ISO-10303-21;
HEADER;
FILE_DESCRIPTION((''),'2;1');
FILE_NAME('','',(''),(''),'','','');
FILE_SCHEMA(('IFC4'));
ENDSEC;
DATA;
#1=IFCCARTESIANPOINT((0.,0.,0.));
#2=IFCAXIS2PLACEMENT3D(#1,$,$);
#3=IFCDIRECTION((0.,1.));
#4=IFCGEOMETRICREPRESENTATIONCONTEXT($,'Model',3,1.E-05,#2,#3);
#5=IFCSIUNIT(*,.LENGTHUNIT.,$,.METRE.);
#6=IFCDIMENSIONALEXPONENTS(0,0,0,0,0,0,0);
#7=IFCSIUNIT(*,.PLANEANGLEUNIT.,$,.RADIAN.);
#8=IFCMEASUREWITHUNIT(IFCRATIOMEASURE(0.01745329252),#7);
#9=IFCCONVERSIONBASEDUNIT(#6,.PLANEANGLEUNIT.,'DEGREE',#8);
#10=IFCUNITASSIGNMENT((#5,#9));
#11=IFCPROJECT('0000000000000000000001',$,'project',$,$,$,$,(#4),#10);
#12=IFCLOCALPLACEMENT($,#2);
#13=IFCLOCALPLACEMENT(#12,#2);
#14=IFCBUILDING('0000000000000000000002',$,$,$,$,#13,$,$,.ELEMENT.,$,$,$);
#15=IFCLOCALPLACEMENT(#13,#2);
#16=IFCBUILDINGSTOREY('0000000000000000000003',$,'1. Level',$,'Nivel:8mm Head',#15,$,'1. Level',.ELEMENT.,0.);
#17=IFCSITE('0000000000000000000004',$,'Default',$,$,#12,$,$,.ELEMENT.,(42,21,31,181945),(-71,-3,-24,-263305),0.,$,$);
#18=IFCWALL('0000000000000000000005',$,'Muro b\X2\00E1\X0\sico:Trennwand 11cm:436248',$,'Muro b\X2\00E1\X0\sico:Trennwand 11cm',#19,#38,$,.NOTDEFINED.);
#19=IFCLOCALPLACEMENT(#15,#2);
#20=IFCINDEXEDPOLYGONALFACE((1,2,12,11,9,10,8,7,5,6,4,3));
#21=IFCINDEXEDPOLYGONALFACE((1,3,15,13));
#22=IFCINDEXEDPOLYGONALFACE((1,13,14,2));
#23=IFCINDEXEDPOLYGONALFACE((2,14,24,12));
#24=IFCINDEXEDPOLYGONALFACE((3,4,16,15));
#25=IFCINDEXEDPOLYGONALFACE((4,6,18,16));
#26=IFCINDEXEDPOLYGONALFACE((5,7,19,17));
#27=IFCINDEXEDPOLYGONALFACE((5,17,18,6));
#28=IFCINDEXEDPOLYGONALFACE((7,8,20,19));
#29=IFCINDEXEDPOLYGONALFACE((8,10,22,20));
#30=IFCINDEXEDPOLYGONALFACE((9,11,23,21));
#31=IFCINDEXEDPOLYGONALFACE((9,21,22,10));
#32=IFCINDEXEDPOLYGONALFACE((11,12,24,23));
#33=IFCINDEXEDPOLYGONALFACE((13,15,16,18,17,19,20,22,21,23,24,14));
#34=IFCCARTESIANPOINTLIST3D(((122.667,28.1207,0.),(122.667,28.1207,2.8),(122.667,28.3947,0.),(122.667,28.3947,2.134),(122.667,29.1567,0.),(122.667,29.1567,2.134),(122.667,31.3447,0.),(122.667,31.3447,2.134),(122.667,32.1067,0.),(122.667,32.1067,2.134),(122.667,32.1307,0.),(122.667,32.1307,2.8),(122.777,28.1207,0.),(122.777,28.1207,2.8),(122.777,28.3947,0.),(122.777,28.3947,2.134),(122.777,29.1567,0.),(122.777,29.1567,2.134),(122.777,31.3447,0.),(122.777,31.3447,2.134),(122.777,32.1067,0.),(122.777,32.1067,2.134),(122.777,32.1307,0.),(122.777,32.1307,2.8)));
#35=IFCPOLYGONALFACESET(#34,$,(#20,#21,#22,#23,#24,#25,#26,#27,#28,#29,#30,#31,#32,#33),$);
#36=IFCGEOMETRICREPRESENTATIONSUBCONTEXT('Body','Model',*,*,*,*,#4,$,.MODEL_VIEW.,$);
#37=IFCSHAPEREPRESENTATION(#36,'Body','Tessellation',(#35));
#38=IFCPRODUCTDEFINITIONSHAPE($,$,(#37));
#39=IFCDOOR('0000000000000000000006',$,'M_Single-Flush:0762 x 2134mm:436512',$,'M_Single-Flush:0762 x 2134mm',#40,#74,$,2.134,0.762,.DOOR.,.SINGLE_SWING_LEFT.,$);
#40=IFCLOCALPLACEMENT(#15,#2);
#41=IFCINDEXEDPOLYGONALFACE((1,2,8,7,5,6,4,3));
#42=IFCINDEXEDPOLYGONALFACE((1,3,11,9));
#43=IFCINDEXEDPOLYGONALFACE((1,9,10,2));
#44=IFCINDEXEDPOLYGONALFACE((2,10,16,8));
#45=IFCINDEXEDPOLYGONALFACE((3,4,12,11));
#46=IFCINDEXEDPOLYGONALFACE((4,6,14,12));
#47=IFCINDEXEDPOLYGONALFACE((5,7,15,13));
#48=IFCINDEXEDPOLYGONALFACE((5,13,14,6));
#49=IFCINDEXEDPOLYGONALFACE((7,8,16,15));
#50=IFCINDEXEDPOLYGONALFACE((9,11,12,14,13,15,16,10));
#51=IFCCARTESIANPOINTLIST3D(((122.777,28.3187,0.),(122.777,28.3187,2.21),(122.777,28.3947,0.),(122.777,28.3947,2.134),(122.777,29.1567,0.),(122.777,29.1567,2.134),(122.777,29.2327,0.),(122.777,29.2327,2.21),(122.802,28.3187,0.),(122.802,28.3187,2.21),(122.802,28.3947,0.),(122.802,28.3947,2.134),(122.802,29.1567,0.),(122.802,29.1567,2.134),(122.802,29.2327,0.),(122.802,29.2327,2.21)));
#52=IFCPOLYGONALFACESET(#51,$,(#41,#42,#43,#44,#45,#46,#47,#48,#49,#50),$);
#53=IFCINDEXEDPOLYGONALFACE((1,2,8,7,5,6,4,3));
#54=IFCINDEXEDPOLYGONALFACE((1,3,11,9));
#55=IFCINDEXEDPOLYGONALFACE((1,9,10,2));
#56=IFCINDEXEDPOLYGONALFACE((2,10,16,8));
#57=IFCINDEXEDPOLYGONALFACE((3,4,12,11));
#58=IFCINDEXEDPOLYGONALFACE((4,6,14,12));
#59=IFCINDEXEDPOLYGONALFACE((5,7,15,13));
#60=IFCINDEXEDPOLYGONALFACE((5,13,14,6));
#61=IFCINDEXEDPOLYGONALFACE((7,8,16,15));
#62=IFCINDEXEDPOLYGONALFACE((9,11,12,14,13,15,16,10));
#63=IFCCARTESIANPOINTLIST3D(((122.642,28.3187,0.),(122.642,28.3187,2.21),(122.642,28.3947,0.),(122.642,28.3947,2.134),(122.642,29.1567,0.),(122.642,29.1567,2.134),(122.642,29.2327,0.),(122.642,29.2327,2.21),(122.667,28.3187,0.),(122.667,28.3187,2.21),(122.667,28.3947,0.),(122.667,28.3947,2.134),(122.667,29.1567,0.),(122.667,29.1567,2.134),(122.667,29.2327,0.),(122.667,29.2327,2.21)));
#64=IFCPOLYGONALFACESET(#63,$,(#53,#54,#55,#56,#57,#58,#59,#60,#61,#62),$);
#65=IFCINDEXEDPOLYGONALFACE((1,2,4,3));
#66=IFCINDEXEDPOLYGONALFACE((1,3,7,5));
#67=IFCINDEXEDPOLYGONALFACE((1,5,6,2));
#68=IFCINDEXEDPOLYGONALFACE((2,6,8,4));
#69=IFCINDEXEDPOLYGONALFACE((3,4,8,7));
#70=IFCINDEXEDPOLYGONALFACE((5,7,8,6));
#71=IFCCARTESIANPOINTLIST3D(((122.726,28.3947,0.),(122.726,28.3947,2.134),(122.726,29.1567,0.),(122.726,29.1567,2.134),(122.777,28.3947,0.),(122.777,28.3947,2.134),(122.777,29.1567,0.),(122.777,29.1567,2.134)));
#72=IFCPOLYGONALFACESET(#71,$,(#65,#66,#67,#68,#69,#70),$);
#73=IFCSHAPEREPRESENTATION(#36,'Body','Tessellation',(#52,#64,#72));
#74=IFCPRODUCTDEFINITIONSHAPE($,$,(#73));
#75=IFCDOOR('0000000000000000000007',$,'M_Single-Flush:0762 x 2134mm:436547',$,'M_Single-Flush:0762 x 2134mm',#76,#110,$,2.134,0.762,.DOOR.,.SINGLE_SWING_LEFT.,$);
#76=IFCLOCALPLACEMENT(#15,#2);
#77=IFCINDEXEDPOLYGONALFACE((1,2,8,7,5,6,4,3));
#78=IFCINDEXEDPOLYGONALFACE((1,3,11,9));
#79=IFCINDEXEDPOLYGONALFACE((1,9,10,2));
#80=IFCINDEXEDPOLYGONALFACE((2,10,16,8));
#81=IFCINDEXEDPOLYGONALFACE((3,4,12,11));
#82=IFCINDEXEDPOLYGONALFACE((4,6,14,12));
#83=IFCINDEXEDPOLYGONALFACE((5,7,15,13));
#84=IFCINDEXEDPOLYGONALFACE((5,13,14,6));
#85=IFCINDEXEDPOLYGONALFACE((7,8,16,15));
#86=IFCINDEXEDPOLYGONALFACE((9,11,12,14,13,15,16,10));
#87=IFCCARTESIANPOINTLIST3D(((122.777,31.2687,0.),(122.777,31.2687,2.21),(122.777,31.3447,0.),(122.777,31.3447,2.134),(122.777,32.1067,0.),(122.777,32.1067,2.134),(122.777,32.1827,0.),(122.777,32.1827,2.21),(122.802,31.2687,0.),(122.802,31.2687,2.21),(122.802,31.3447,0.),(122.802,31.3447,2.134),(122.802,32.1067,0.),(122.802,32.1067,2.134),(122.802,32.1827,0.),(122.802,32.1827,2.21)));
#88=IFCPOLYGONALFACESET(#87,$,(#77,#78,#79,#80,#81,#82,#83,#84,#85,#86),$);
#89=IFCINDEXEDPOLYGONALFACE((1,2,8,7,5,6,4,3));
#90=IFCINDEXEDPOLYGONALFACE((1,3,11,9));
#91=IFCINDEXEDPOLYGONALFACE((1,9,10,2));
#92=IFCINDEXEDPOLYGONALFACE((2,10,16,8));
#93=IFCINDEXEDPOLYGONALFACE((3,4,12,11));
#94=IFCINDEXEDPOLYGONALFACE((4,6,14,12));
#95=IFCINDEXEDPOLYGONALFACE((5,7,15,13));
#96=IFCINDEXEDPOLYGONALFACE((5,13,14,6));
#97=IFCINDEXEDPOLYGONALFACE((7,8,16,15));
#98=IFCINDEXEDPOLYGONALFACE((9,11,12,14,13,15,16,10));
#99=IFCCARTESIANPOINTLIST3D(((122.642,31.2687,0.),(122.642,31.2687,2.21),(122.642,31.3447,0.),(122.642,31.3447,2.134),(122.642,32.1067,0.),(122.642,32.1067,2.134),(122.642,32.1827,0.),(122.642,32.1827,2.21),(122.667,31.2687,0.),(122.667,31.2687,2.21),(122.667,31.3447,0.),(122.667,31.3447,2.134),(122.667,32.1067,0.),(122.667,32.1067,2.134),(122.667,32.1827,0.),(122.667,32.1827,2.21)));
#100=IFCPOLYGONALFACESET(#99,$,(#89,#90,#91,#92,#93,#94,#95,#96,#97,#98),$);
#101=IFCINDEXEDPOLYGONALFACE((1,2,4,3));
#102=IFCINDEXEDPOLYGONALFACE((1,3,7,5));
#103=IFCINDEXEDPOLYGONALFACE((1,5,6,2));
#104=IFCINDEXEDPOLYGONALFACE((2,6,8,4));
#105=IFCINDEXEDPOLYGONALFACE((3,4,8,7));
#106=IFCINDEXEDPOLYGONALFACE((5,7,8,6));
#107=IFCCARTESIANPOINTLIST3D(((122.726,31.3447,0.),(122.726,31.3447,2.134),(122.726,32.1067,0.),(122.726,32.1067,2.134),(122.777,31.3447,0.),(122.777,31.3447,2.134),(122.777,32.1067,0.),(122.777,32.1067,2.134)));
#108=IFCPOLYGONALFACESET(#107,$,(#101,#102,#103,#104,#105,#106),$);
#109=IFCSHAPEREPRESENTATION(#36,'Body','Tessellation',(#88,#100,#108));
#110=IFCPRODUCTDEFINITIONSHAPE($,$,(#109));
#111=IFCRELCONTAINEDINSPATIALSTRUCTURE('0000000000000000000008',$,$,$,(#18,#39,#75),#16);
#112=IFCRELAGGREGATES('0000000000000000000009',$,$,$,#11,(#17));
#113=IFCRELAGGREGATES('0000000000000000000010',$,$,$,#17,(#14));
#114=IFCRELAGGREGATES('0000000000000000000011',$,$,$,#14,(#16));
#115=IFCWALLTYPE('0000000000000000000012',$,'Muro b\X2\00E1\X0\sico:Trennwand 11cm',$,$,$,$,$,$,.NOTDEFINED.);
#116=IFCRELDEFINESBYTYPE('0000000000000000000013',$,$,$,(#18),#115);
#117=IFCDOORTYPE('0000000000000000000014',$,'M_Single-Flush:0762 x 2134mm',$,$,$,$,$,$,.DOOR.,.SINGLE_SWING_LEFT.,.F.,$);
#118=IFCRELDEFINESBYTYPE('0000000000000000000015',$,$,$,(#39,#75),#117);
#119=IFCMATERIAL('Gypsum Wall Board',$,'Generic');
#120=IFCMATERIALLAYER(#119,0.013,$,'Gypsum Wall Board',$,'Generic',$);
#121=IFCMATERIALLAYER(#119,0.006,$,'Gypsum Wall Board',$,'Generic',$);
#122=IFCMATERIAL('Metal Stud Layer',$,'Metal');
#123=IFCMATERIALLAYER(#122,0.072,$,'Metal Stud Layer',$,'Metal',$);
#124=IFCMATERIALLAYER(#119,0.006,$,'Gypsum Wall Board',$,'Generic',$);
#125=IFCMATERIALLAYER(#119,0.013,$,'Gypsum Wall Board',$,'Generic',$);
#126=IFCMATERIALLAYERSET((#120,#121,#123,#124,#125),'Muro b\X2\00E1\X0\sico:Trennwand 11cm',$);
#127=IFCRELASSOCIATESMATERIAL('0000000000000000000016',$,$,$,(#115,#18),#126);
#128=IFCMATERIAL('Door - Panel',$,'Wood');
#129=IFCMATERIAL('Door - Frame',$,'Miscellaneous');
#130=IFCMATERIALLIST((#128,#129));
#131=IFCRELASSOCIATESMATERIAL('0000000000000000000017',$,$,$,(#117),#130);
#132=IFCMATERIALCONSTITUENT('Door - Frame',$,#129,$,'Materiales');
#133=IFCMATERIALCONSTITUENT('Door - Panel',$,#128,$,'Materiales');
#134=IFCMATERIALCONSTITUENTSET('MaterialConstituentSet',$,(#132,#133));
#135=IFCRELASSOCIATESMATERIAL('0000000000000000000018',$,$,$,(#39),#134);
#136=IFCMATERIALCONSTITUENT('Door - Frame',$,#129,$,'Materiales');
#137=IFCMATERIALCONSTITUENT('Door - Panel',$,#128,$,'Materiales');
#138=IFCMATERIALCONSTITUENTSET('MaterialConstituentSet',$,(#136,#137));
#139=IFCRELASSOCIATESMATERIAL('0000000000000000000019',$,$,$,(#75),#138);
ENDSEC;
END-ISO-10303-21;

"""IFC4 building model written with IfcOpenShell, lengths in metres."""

from ifc_helpers import new_model, entity, si_unit, converted_unit, direction, frame, frame_2d, origin, origin_2d_with_axis, place, context, subcontext, project, spatial, polyline, rectangle, outline, extrude, source, transform, mapped, material, material_list, layer, layer_set, layer_usage, constituent, constituent_set, type_object, type_shapes, element, fill, save


model = new_model("IFC4")

# Units and contexts
model_context = context("Model", 3, precision=1e-05, world=origin(), true_north=direction((0.0, 1.0)))
body_context = subcontext(model_context, "Body", "Model", "MODEL_VIEW")
ifc_project = project(units=[si_unit("LENGTHUNIT", "METRE"), converted_unit("PLANEANGLEUNIT", "DEGREE", entity("IfcRatioMeasure", 0.01745329252), si_unit("PLANEANGLEUNIT", "RADIAN"), dimensions=[0, 0, 0, 0, 0, 0, 0])], contexts=[model_context])

# Site, building, storey
site_placement = place(None, origin())
site = spatial("IfcSite", under=ifc_project, at=site_placement, Name="Default", CompositionType="ELEMENT", RefLatitude=(42, 21, 31, 181945), RefLongitude=(-71, -3, -24, -263305), RefElevation=0.0)
building_placement = place(site_placement, origin())
building = spatial("IfcBuilding", under=site, at=building_placement, CompositionType="ELEMENT")
storey_placement = place(building_placement, origin())
storey = spatial("IfcBuildingStorey", under=building, at=storey_placement, Name="1. Level", ObjectType="Nivel:8mm Head", LongName="1. Level", CompositionType="ELEMENT", Elevation=0.0)

# Shared definitions
ifc_material_1 = material(Name="Gypsum Wall Board", Category="Generic")
ifc_layer_1 = layer(ifc_material_1, 0.013, Name="Gypsum Wall Board", Category="Generic")
ifc_layer_2 = layer(ifc_material_1, 0.006, Name="Gypsum Wall Board", Category="Generic")
ifc_material_2 = material(Name="Metal Stud Layer", Category="Metal")
ifc_layer_3 = layer(ifc_material_2, 0.072, Name="Metal Stud Layer", Category="Metal")
ifc_layer_4 = layer(ifc_material_1, 0.006, Name="Gypsum Wall Board", Category="Generic")
ifc_layer_5 = layer(ifc_material_1, 0.013, Name="Gypsum Wall Board", Category="Generic")
ifc_layer_set_1 = layer_set([ifc_layer_1, ifc_layer_2, ifc_layer_3, ifc_layer_4, ifc_layer_5], Name="Muro básico:Trennwand 11cm")
wall_type_1 = type_object("IfcWallType", Name="Muro básico:Trennwand 11cm", PredefinedType="NOTDEFINED", material=ifc_layer_set_1)
ifc_material_3 = material(Name="Door - Frame", Category="Miscellaneous")
ifc_material_4 = material(Name="Door - Panel", Category="Wood")
ifc_material_list_1 = material_list([ifc_material_4, ifc_material_3])
door_type_1 = type_object("IfcDoorType", Name="M_Single-Flush:0762 x 2134mm", OperationType="SINGLE_SWING_LEFT", ParameterTakesPrecedence=False, PredefinedType="DOOR", material=ifc_material_list_1)
shared_shape_1 = source(origin(), body_context, "Body", "SweptSolid", [
    extrude(outline(polyline([(-0.457, -1.124), (0.457, -1.124), (0.457, 1.086), (0.381, 1.086), (0.381, -1.048), (-0.381, -1.048), (-0.381, 1.086), (-0.457, 1.086), (-0.457, -1.124)])), frame((0.381, 0.135, 1.086), z_axis=(0.0, -1.0, 0.0), x_axis=(-1.0, 0.0, 0.0)), (0.0, 0.0, 1.0), 0.025),
    extrude(outline(polyline([(-1.124, -0.457), (1.086, -0.457), (1.086, -0.381), (-1.048, -0.381), (-1.048, 0.381), (1.086, 0.381), (1.086, 0.457), (-1.124, 0.457), (-1.124, -0.457)])), frame((0.381, 0.0, 1.086), z_axis=(0.0, -1.0, 0.0), x_axis=(0.0, 0.0, -1.0)), (0.0, 0.0, 1.0), 0.025),
    extrude(rectangle(XDim=0.762, YDim=0.051, at=origin_2d_with_axis()), frame((0.381, 0.0845, 0.0)), (0.0, 0.0, 1.0), 2.134),
])
type_shapes(door_type_1, [shared_shape_1])

# Wall, openings, doors
ifc_layer_usage_1 = layer_usage(ifc_layer_set_1, "AXIS2", "NEGATIVE", 0.055)
wall_1_placement = place(storey_placement, frame((122.722, 28.1207, 0.0), z_axis=(0.0, 0.0, 1.0), x_axis=(0.0, 1.0, 0.0)))
wall_1 = element("IfcWall", 1, at=wall_1_placement, inside=storey, type_object=wall_type_1, material=ifc_layer_usage_1, Name="Muro básico:Trennwand 11cm:436248", ObjectType="Muro básico:Trennwand 11cm", PredefinedType="NOTDEFINED", context=body_context, shape_type="SweptSolid", body=[
    extrude(rectangle(XDim=4.01, YDim=0.11, at=frame_2d((2.005, 0.0), x_axis=(-1.0, 0.0))), origin(), (0.0, 0.0, 1.0), 2.8),
])
opening_1_placement = place(wall_1_placement, frame((1.036, 0.055, 0.0)))
opening_1 = element("IfcOpeningElement", 2, at=opening_1_placement, cuts=wall_1, ObjectType="Opening", PredefinedType="OPENING", context=body_context, shape_type="SweptSolid", body=[
    extrude(rectangle(XDim=0.762, YDim=2.134, at=frame_2d((1.067, 0.381), x_axis=(0.0, -1.0))), frame((0.0, 0.0, 0.0), z_axis=(0.0, -1.0, 0.0), x_axis=(0.0, 0.0, 1.0)), (0.0, 0.0, 1.0), 0.11),
])
opening_2_placement = place(wall_1_placement, frame((3.986, 0.055, 0.0)))
opening_2 = element("IfcOpeningElement", 3, at=opening_2_placement, cuts=wall_1, ObjectType="Opening", PredefinedType="OPENING", context=body_context, shape_type="SweptSolid", body=[
    extrude(rectangle(XDim=0.762, YDim=2.134, at=frame_2d((1.067, 0.381), x_axis=(0.0, -1.0))), frame((0.0, 0.0, 0.0), z_axis=(0.0, -1.0, 0.0), x_axis=(0.0, 0.0, 1.0)), (0.0, 0.0, 1.0), 0.11),
])
ifc_constituent_1 = constituent(ifc_material_3, Name="Door - Frame", Category="Materiales")
ifc_constituent_2 = constituent(ifc_material_4, Name="Door - Panel", Category="Materiales")
ifc_constituent_set_1 = constituent_set(constituents=[ifc_constituent_1, ifc_constituent_2], Name="MaterialConstituentSet")
door_1_placement = place(opening_1_placement, frame((0.0, 0.0, 0.0), z_axis=(0.0, 0.0, 1.0), x_axis=(-1.0, 0.0, 0.0)))
door_1 = element("IfcDoor", 4, at=door_1_placement, inside=storey, type_object=door_type_1, material=ifc_constituent_set_1, Name="M_Single-Flush:0762 x 2134mm:436512", ObjectType="M_Single-Flush:0762 x 2134mm", OperationType="SINGLE_SWING_LEFT", OverallHeight=2.134, OverallWidth=0.762, PredefinedType="DOOR", context=body_context, shape_type="MappedRepresentation", body=[
    mapped(shared_shape_1, transform((0.0, 0.0, 0.0), scale=1.0)),
])
fill(opening_1, door_1)
ifc_constituent_3 = constituent(ifc_material_3, Name="Door - Frame", Category="Materiales")
ifc_constituent_4 = constituent(ifc_material_4, Name="Door - Panel", Category="Materiales")
ifc_constituent_set_2 = constituent_set(constituents=[ifc_constituent_3, ifc_constituent_4], Name="MaterialConstituentSet")
door_2_placement = place(opening_2_placement, frame((0.0, 0.0, 0.0), z_axis=(0.0, 0.0, 1.0), x_axis=(-1.0, 0.0, 0.0)))
door_2 = element("IfcDoor", 5, at=door_2_placement, inside=storey, type_object=door_type_1, material=ifc_constituent_set_2, Name="M_Single-Flush:0762 x 2134mm:436547", ObjectType="M_Single-Flush:0762 x 2134mm", OperationType="SINGLE_SWING_LEFT", OverallHeight=2.134, OverallWidth=0.762, PredefinedType="DOOR", context=body_context, shape_type="MappedRepresentation", body=[
    mapped(shared_shape_1, transform((0.0, 0.0, 0.0), scale=1.0)),
])
fill(opening_2, door_2)

save(model, "model.ifc")
